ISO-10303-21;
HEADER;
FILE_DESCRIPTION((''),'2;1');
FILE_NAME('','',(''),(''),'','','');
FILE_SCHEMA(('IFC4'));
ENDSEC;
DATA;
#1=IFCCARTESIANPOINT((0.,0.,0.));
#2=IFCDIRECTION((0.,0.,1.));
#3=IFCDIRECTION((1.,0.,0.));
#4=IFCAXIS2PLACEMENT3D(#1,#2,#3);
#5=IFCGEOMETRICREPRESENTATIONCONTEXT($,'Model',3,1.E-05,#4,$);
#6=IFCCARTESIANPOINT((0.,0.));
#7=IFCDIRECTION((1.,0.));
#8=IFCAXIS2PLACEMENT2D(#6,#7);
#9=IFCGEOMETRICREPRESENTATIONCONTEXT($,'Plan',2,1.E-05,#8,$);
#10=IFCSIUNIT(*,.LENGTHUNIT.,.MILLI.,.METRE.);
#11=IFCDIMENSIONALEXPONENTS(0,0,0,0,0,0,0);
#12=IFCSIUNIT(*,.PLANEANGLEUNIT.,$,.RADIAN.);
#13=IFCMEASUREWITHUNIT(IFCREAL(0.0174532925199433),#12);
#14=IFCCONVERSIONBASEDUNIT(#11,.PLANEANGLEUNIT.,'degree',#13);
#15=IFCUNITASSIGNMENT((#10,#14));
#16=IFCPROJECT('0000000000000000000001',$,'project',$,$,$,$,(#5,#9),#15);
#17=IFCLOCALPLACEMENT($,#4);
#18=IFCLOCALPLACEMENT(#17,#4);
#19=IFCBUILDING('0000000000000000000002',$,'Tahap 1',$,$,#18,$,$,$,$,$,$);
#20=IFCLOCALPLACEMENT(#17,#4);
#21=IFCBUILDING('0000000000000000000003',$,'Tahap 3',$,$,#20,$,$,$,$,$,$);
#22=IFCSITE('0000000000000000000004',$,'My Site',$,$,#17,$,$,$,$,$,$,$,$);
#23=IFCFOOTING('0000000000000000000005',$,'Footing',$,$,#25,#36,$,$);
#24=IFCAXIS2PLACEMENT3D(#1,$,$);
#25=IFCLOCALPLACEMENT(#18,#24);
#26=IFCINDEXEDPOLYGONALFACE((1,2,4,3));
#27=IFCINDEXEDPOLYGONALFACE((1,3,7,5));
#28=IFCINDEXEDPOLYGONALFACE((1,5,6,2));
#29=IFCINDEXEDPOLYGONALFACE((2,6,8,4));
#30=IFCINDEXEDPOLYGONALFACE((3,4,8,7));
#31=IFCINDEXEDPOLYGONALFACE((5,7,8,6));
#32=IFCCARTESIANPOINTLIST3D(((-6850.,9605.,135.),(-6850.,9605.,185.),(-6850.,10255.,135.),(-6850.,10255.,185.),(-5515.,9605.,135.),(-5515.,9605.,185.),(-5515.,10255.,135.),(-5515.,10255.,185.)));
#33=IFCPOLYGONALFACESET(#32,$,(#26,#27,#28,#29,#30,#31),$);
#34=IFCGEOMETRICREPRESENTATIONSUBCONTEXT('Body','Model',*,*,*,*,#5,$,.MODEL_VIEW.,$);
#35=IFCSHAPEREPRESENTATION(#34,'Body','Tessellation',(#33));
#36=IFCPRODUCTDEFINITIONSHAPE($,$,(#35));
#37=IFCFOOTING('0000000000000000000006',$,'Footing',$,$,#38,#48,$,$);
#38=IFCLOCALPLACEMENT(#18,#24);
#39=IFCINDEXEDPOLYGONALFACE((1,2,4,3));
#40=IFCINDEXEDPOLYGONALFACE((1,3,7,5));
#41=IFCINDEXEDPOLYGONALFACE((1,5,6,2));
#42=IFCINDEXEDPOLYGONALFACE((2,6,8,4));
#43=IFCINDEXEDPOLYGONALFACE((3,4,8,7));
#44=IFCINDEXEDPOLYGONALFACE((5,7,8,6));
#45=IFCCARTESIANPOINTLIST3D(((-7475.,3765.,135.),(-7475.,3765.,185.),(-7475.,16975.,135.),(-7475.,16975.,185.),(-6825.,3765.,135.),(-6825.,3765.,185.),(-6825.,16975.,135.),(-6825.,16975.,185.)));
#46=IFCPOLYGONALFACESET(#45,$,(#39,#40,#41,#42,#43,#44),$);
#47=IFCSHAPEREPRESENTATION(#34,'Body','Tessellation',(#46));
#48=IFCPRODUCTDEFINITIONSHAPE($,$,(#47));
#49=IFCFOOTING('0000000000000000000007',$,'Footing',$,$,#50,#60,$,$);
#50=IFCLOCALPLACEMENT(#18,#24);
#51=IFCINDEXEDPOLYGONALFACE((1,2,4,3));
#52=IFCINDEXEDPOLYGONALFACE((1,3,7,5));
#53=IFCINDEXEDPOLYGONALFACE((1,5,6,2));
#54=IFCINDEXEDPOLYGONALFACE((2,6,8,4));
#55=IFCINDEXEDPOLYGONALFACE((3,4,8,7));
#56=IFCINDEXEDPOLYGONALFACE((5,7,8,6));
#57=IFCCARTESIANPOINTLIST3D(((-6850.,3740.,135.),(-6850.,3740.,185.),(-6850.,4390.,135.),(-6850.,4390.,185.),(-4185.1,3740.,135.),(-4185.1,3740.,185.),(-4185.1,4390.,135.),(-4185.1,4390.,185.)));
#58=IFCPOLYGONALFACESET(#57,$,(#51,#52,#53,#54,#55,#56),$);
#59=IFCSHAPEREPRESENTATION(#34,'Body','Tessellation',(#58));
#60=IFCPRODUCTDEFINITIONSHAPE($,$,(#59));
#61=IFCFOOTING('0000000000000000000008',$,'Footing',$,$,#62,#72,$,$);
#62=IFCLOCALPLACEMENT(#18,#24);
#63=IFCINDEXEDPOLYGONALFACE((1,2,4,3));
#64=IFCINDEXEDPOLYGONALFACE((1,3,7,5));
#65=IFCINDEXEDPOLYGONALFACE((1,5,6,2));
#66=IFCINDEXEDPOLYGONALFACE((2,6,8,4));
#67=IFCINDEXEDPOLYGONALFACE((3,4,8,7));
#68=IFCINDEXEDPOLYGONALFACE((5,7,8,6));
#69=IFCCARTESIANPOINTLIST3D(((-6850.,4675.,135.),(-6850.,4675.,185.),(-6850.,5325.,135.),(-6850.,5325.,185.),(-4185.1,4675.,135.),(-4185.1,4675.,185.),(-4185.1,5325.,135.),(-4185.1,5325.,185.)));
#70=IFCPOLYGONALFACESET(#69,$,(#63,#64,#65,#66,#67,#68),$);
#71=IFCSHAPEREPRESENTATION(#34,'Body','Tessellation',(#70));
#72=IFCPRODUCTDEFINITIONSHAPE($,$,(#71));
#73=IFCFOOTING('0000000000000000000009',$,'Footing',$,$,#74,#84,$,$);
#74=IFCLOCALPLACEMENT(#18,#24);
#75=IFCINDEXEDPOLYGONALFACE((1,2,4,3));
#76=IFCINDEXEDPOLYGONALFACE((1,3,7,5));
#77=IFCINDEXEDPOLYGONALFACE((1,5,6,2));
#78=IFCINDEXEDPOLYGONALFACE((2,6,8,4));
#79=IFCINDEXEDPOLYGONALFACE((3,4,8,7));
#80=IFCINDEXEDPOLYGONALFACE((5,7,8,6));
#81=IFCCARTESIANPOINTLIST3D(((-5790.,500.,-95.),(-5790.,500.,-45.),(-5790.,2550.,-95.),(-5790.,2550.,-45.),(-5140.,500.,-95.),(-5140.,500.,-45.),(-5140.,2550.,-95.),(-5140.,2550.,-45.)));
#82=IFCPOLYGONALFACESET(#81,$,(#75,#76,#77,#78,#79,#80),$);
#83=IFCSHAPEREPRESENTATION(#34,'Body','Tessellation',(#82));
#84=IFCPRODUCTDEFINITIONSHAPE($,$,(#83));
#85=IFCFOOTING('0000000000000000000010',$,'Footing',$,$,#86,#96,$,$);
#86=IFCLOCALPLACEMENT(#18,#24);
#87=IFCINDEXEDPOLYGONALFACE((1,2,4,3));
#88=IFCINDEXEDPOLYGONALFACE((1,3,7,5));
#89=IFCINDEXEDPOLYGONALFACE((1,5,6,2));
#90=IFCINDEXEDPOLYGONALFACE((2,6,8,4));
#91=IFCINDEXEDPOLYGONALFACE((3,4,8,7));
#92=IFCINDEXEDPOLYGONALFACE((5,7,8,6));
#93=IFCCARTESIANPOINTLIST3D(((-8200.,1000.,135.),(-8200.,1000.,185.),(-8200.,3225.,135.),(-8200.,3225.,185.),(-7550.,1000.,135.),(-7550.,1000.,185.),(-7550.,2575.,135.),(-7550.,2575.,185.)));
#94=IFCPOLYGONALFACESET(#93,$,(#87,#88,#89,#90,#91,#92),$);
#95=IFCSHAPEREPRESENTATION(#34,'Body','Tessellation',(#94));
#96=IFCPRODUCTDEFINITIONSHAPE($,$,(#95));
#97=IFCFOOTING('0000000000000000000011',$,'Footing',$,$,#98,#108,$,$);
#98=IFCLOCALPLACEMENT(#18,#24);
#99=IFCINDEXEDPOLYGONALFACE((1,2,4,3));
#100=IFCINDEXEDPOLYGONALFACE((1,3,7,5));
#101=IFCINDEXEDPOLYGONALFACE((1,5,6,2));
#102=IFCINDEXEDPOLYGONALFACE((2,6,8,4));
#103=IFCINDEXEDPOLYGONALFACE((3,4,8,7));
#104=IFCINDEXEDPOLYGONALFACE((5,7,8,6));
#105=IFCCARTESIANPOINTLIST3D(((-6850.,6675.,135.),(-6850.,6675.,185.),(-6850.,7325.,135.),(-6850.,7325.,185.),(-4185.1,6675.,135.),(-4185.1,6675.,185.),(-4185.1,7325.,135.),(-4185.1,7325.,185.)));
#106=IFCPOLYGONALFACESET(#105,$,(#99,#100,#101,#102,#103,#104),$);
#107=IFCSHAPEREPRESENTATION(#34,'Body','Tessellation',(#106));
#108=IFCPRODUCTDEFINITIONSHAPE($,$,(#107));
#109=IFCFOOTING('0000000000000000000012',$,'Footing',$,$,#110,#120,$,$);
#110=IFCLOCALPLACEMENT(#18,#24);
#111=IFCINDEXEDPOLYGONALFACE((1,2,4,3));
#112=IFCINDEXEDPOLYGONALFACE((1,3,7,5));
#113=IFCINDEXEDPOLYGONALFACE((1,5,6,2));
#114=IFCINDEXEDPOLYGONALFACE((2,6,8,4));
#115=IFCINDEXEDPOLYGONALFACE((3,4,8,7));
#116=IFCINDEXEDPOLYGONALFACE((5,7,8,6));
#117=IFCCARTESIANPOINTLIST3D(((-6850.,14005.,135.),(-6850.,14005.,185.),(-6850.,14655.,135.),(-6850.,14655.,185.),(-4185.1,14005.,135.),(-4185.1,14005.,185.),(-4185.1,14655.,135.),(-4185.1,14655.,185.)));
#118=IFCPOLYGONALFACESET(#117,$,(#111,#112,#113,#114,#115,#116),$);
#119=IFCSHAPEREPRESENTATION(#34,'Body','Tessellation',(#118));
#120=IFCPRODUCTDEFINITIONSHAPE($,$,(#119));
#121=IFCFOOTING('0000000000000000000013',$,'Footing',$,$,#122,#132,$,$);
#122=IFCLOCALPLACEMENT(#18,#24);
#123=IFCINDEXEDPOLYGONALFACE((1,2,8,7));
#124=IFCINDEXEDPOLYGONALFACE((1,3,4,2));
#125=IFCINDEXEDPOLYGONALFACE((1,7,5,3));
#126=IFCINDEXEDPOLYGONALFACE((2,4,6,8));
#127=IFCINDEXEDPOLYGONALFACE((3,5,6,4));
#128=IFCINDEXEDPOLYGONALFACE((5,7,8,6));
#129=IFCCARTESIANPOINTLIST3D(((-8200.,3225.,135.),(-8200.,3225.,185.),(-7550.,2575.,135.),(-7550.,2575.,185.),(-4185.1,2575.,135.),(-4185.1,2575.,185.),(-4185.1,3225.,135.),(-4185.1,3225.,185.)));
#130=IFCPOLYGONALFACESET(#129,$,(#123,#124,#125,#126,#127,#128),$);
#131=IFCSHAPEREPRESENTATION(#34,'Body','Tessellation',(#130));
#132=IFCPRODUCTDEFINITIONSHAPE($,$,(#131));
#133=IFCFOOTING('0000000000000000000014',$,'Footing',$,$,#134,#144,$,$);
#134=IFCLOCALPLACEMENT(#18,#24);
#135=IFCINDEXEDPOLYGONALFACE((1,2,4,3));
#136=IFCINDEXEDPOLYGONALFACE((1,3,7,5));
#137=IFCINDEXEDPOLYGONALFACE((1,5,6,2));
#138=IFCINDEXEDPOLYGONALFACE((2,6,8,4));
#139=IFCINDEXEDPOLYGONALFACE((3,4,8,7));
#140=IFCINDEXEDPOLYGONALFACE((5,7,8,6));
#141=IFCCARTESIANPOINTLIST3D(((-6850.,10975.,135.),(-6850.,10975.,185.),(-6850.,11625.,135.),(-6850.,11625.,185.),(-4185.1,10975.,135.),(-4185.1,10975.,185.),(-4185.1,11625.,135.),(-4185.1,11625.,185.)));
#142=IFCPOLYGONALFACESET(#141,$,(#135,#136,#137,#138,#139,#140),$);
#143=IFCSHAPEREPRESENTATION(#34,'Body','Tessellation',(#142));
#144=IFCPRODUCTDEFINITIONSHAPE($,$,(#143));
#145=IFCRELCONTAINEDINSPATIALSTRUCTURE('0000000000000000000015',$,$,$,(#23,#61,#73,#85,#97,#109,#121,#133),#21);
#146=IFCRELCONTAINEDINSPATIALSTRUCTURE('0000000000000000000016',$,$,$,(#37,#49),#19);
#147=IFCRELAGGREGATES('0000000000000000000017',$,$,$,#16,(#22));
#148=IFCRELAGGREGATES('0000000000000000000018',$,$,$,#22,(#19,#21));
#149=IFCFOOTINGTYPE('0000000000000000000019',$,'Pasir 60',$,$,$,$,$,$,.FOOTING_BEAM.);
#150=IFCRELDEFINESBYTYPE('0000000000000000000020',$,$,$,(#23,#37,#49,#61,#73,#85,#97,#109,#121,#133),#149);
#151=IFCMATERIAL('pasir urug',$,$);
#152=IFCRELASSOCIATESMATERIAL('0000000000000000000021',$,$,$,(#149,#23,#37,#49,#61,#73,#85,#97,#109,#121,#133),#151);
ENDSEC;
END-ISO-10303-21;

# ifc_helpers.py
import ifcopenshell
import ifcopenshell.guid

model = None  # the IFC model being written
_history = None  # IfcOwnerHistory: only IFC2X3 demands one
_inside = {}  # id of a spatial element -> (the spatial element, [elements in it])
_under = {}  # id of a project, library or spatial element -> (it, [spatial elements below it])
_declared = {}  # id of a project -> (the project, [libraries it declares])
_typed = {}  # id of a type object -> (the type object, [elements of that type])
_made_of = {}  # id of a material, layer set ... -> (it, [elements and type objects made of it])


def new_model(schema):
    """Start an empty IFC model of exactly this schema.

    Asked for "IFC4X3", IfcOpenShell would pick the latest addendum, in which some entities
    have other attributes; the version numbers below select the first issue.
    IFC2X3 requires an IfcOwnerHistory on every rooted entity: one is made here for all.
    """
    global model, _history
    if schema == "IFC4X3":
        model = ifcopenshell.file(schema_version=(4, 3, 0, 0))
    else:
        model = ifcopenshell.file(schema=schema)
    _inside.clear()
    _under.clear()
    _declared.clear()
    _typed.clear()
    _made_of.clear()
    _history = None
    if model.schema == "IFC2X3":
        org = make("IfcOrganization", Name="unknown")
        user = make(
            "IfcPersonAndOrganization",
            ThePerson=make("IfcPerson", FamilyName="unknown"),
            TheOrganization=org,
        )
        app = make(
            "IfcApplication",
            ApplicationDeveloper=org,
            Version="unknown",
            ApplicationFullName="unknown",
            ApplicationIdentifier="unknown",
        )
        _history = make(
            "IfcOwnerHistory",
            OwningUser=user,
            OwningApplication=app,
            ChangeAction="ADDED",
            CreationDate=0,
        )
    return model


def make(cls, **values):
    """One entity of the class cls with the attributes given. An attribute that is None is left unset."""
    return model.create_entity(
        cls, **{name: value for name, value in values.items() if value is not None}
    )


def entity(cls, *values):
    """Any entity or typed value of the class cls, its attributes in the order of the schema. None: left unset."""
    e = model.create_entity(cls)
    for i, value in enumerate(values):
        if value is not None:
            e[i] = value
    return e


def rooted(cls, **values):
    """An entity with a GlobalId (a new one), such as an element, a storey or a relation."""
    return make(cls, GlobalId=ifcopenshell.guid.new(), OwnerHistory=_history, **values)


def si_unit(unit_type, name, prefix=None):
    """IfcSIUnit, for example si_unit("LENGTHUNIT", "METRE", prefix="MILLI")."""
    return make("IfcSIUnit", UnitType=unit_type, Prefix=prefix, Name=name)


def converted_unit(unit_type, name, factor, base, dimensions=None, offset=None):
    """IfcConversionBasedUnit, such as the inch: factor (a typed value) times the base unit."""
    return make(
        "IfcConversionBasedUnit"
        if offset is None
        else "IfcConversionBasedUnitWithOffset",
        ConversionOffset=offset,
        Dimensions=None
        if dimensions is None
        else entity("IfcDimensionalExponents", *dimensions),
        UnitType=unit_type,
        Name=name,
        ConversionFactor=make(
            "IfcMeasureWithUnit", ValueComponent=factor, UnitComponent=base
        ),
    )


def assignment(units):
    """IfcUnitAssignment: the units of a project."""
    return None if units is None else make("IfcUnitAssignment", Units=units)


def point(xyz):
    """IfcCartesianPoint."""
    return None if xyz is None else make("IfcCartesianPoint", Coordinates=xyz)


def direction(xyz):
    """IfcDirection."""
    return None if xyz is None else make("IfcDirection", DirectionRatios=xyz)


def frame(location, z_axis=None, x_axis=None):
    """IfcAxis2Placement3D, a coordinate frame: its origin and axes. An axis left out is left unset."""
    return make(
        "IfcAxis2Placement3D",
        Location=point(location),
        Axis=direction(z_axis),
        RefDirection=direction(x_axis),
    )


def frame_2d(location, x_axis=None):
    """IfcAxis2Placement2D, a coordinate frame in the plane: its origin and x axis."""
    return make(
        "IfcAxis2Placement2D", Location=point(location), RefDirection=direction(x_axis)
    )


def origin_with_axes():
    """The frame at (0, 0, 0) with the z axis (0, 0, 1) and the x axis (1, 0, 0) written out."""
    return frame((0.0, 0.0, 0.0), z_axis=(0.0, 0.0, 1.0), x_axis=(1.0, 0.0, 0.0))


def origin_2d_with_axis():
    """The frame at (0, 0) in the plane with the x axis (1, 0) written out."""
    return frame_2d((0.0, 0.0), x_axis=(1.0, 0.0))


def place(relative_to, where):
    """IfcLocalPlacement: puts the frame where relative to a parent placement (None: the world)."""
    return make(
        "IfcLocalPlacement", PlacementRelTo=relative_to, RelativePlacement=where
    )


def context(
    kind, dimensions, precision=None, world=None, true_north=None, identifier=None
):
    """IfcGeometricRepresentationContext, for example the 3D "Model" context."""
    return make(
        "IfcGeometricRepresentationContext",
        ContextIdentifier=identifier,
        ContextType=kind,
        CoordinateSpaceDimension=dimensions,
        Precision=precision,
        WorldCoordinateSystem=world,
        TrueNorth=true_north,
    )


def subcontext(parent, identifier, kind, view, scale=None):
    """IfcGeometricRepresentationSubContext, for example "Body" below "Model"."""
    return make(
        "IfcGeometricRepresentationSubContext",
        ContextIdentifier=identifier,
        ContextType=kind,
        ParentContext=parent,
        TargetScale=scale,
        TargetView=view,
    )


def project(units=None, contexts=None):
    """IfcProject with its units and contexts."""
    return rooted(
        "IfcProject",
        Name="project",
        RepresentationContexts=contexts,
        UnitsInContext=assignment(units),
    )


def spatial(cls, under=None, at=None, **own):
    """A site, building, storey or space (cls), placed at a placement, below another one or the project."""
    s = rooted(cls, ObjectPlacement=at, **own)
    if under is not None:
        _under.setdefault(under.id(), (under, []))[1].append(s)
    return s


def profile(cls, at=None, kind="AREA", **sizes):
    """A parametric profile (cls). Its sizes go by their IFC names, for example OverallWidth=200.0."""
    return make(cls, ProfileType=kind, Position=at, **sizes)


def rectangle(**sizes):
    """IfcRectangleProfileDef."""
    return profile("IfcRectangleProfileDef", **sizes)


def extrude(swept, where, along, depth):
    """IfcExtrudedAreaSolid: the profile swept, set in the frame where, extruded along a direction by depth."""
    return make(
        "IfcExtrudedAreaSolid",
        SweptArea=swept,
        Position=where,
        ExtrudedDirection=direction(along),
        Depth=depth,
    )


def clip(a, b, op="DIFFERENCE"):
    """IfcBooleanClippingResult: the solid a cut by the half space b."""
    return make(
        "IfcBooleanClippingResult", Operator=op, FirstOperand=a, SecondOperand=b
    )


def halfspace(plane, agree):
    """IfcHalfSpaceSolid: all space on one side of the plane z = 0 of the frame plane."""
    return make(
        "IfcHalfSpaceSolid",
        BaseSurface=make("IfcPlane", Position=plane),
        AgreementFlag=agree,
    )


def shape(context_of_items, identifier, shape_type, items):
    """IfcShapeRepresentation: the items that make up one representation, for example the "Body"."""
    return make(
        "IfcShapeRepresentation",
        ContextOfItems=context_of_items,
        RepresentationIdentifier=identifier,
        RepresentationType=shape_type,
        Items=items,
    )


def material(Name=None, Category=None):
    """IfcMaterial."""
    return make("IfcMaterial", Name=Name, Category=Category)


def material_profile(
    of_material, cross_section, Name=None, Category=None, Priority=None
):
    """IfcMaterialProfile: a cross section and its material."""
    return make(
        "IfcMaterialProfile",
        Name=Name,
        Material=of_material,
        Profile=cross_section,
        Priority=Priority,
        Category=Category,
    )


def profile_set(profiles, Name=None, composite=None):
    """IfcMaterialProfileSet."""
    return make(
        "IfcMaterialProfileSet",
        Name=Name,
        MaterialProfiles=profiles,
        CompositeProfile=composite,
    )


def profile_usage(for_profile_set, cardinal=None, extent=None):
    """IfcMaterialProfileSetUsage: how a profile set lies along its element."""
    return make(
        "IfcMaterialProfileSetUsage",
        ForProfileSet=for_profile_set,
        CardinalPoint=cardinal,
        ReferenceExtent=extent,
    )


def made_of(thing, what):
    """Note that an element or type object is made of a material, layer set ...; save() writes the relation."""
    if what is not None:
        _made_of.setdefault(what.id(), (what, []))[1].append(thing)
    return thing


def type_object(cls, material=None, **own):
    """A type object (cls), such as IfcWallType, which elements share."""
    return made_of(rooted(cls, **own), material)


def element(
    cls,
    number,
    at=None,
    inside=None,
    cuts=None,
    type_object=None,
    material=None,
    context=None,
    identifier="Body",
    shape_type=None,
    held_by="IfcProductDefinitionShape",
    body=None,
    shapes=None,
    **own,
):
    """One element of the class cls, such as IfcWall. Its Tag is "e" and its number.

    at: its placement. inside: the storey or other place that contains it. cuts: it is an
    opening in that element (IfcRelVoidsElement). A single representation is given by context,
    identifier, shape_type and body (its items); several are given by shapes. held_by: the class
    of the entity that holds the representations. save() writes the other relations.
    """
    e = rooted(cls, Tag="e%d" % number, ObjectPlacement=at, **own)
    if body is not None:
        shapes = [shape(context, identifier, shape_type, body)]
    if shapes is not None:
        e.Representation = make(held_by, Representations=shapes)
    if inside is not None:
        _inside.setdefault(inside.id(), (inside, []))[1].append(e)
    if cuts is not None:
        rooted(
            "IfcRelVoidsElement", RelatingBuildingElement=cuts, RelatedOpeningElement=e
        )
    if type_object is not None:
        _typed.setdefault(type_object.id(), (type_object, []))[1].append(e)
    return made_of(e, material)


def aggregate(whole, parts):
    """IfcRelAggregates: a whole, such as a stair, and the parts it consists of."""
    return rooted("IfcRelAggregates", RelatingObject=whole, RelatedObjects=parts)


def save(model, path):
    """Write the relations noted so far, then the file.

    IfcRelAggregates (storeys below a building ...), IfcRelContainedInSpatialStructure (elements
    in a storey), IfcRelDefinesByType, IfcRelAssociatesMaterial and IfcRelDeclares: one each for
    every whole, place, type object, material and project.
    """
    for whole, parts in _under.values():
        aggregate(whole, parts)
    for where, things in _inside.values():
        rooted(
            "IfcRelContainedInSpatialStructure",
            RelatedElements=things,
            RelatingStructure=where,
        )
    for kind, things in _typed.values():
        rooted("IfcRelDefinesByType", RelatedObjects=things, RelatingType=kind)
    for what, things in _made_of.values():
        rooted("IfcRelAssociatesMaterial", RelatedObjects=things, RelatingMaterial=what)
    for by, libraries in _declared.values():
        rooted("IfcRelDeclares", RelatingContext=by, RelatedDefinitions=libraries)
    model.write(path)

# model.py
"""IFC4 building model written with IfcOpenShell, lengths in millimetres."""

from ifc_helpers import new_model, entity, si_unit, converted_unit, frame, origin_with_axes, origin_2d_with_axis, place, context, subcontext, project, spatial, rectangle, extrude, clip, halfspace, material, material_profile, profile_set, profile_usage, type_object, element, save


model = new_model("IFC4")

# Units and contexts
model_context = context("Model", 3, precision=1e-05, world=origin_with_axes())
plan_context = context("Plan", 2, precision=1e-05, world=origin_2d_with_axis())
body_context = subcontext(model_context, "Body", "Model", "MODEL_VIEW")
ifc_project = project(units=[si_unit("LENGTHUNIT", "METRE", prefix="MILLI"), converted_unit("PLANEANGLEUNIT", "degree", entity("IfcReal", 0.0174532925199433), si_unit("PLANEANGLEUNIT", "RADIAN"), dimensions=[0, 0, 0, 0, 0, 0, 0])], contexts=[model_context, plan_context])

# Site, building
site_placement = place(None, origin_with_axes())
site = spatial("IfcSite", under=ifc_project, at=site_placement, Name="My Site")
building_1_placement = place(site_placement, origin_with_axes())
building_1 = spatial("IfcBuilding", under=site, at=building_1_placement, Name="Tahap 1")

# Shared definitions
building_2_placement = place(site_placement, origin_with_axes())
building_2 = spatial("IfcBuilding", under=site, at=building_2_placement, Name="Tahap 3")

# Footings
ifc_material_1 = material(Name="pasir urug")
ifc_material_profile_1 = material_profile(ifc_material_1, rectangle(XDim=650.0, YDim=50.0, kind="CURVE"))
ifc_profile_set_1 = profile_set([ifc_material_profile_1])
ifc_profile_usage_1 = profile_usage(ifc_profile_set_1, cardinal=8)
footing_type_1 = type_object("IfcFootingType", Name="Pasir 60", PredefinedType="FOOTING_BEAM", material=ifc_profile_set_1)
footing_1_placement = place(building_2_placement, frame((-6850.0, 9930.0, 185.0), z_axis=(1.0, 0.0, 0.0), x_axis=(0.0, 1.0, 0.0)))
element("IfcFooting", 1, at=footing_1_placement, inside=building_2, type_object=footing_type_1, material=ifc_profile_usage_1, Name="Footing", context=body_context, shape_type="SweptSolid", body=[
    extrude(rectangle(XDim=650.0, YDim=50.0, kind="CURVE"), frame((0.0, -25.0, 0.0), z_axis=(0.0, 0.0, 1.0), x_axis=(1.0, 0.0, 0.0)), (0.0, 0.0, 1.0), 1335.0),
])
ifc_profile_usage_2 = profile_usage(ifc_profile_set_1, cardinal=8)
footing_2_placement = place(building_1_placement, frame((-7150.0, 3765.0, 185.0), z_axis=(0.0, 1.0, 0.0), x_axis=(-1.0, 0.0, 0.0)))
element("IfcFooting", 2, at=footing_2_placement, inside=building_1, type_object=footing_type_1, material=ifc_profile_usage_2, Name="Footing", context=body_context, shape_type="SweptSolid", body=[
    extrude(rectangle(XDim=650.0, YDim=50.0, kind="CURVE"), frame((0.0, -25.0, 0.0), z_axis=(0.0, 0.0, 1.0), x_axis=(1.0, 0.0, 0.0)), (0.0, 0.0, 1.0), 13210.0),
])
ifc_profile_usage_3 = profile_usage(ifc_profile_set_1, cardinal=8)
footing_3_placement = place(building_1_placement, frame((-6850.0, 4065.0, 185.0), z_axis=(1.0, 0.0, 0.0), x_axis=(0.0, 1.0, 0.0)))
element("IfcFooting", 3, at=footing_3_placement, inside=building_1, type_object=footing_type_1, material=ifc_profile_usage_3, Name="Footing", context=body_context, shape_type="SweptSolid", body=[
    extrude(rectangle(XDim=650.0, YDim=50.0, kind="CURVE"), frame((0.0, -25.0, 0.0), z_axis=(0.0, 0.0, 1.0), x_axis=(1.0, 0.0, 0.0)), (0.0, 0.0, 1.0), 2664.9),
])
ifc_profile_usage_4 = profile_usage(ifc_profile_set_1, cardinal=8)
footing_4_placement = place(building_2_placement, frame((-6850.0, 5000.0, 185.0), z_axis=(1.0, 0.0, 0.0), x_axis=(0.0, 1.0, 0.0)))
element("IfcFooting", 4, at=footing_4_placement, inside=building_2, type_object=footing_type_1, material=ifc_profile_usage_4, Name="Footing", context=body_context, shape_type="SweptSolid", body=[
    extrude(rectangle(XDim=650.0, YDim=50.0, kind="CURVE"), frame((0.0, -25.0, 0.0), z_axis=(0.0, 0.0, 1.0), x_axis=(1.0, 0.0, 0.0)), (0.0, 0.0, 1.0), 2664.9),
])
ifc_profile_usage_5 = profile_usage(ifc_profile_set_1, cardinal=8)
footing_5_placement = place(building_2_placement, frame((-5465.0, 500.0, -45.0), z_axis=(0.000001, 1.0, 0.0), x_axis=(-1.0, 0.000001, 0.0)))
element("IfcFooting", 5, at=footing_5_placement, inside=building_2, type_object=footing_type_1, material=ifc_profile_usage_5, Name="Footing", context=body_context, shape_type="SweptSolid", body=[
    extrude(rectangle(XDim=650.0, YDim=50.0, kind="CURVE"), frame((0.0, -25.0, 0.0), z_axis=(0.0, 0.0, 1.0), x_axis=(1.0, 0.0, 0.0)), (0.0, 0.0, 1.0), 2050.0),
])
ifc_profile_usage_6 = profile_usage(ifc_profile_set_1, cardinal=8)
footing_6_placement = place(building_2_placement, frame((-7875.0, 3225.0, 185.0), z_axis=(0.0, -1.0, 0.0), x_axis=(1.0, 0.0, 0.0)))
element("IfcFooting", 6, at=footing_6_placement, inside=building_2, type_object=footing_type_1, material=ifc_profile_usage_6, Name="Footing", context=body_context, shape_type="Clipping", body=[
    clip(extrude(rectangle(XDim=650.0, YDim=50.0, kind="CURVE"), frame((0.0, -25.0, 0.0), z_axis=(0.0, 0.0, 1.0), x_axis=(1.0, 0.0, 0.0)), (0.0, 0.0, 1.0), 2225.0), halfspace(frame((-325.0, -185.0, 0.0), z_axis=(0.707108, 0.0, -0.707106), x_axis=(0.0, -1.0, 0.0)), False)),
])
ifc_profile_usage_7 = profile_usage(ifc_profile_set_1, cardinal=8)
footing_7_placement = place(building_2_placement, frame((-6850.0, 7000.0, 185.0), z_axis=(1.0, 0.0, 0.0), x_axis=(0.0, 1.0, 0.0)))
element("IfcFooting", 7, at=footing_7_placement, inside=building_2, type_object=footing_type_1, material=ifc_profile_usage_7, Name="Footing", context=body_context, shape_type="SweptSolid", body=[
    extrude(rectangle(XDim=650.0, YDim=50.0, kind="CURVE"), frame((0.0, -25.0, 0.0), z_axis=(0.0, 0.0, 1.0), x_axis=(1.0, 0.0, 0.0)), (0.0, 0.0, 1.0), 2664.9),
])
ifc_profile_usage_8 = profile_usage(ifc_profile_set_1, cardinal=8)
footing_8_placement = place(building_2_placement, frame((-6850.0, 14330.0, 185.0), z_axis=(1.0, 0.0, 0.0), x_axis=(0.0, 1.0, 0.0)))
element("IfcFooting", 8, at=footing_8_placement, inside=building_2, type_object=footing_type_1, material=ifc_profile_usage_8, Name="Footing", context=body_context, shape_type="SweptSolid", body=[
    extrude(rectangle(XDim=650.0, YDim=50.0, kind="CURVE"), frame((0.0, -25.0, 0.0), z_axis=(0.0, 0.0, 1.0), x_axis=(1.0, 0.0, 0.0)), (0.0, 0.0, 1.0), 2664.9),
])
ifc_profile_usage_9 = profile_usage(ifc_profile_set_1, cardinal=8)
footing_9_placement = place(building_2_placement, frame((-8200.0, 2900.0, 185.0), z_axis=(1.0, 0.0, 0.0), x_axis=(0.0, 1.0, 0.0)))
element("IfcFooting", 9, at=footing_9_placement, inside=building_2, type_object=footing_type_1, material=ifc_profile_usage_9, Name="Footing", context=body_context, shape_type="Clipping", body=[
    clip(extrude(rectangle(XDim=650.0, YDim=50.0, kind="CURVE"), frame((0.0, -25.0, 0.0), z_axis=(0.0, 0.0, 1.0), x_axis=(1.0, 0.0, 0.0)), (0.0, 0.0, 1.0), 4014.9), halfspace(frame((325.0, -185.0, 0.0), z_axis=(-0.707106, 0.0, -0.707107), x_axis=(0.0, 1.0, 0.0)), False)),
])
ifc_profile_usage_10 = profile_usage(ifc_profile_set_1, cardinal=8)
footing_10_placement = place(building_2_placement, frame((-6850.0, 11300.0, 185.0), z_axis=(1.0, 0.0, 0.0), x_axis=(0.0, 1.0, 0.0)))
element("IfcFooting", 10, at=footing_10_placement, inside=building_2, type_object=footing_type_1, material=ifc_profile_usage_10, Name="Footing", context=body_context, shape_type="SweptSolid", body=[
    extrude(rectangle(XDim=650.0, YDim=50.0, kind="CURVE"), frame((0.0, -25.0, 0.0), z_axis=(0.0, 0.0, 1.0), x_axis=(1.0, 0.0, 0.0)), (0.0, 0.0, 1.0), 2664.9),
])

save(model, "model.ifc")
